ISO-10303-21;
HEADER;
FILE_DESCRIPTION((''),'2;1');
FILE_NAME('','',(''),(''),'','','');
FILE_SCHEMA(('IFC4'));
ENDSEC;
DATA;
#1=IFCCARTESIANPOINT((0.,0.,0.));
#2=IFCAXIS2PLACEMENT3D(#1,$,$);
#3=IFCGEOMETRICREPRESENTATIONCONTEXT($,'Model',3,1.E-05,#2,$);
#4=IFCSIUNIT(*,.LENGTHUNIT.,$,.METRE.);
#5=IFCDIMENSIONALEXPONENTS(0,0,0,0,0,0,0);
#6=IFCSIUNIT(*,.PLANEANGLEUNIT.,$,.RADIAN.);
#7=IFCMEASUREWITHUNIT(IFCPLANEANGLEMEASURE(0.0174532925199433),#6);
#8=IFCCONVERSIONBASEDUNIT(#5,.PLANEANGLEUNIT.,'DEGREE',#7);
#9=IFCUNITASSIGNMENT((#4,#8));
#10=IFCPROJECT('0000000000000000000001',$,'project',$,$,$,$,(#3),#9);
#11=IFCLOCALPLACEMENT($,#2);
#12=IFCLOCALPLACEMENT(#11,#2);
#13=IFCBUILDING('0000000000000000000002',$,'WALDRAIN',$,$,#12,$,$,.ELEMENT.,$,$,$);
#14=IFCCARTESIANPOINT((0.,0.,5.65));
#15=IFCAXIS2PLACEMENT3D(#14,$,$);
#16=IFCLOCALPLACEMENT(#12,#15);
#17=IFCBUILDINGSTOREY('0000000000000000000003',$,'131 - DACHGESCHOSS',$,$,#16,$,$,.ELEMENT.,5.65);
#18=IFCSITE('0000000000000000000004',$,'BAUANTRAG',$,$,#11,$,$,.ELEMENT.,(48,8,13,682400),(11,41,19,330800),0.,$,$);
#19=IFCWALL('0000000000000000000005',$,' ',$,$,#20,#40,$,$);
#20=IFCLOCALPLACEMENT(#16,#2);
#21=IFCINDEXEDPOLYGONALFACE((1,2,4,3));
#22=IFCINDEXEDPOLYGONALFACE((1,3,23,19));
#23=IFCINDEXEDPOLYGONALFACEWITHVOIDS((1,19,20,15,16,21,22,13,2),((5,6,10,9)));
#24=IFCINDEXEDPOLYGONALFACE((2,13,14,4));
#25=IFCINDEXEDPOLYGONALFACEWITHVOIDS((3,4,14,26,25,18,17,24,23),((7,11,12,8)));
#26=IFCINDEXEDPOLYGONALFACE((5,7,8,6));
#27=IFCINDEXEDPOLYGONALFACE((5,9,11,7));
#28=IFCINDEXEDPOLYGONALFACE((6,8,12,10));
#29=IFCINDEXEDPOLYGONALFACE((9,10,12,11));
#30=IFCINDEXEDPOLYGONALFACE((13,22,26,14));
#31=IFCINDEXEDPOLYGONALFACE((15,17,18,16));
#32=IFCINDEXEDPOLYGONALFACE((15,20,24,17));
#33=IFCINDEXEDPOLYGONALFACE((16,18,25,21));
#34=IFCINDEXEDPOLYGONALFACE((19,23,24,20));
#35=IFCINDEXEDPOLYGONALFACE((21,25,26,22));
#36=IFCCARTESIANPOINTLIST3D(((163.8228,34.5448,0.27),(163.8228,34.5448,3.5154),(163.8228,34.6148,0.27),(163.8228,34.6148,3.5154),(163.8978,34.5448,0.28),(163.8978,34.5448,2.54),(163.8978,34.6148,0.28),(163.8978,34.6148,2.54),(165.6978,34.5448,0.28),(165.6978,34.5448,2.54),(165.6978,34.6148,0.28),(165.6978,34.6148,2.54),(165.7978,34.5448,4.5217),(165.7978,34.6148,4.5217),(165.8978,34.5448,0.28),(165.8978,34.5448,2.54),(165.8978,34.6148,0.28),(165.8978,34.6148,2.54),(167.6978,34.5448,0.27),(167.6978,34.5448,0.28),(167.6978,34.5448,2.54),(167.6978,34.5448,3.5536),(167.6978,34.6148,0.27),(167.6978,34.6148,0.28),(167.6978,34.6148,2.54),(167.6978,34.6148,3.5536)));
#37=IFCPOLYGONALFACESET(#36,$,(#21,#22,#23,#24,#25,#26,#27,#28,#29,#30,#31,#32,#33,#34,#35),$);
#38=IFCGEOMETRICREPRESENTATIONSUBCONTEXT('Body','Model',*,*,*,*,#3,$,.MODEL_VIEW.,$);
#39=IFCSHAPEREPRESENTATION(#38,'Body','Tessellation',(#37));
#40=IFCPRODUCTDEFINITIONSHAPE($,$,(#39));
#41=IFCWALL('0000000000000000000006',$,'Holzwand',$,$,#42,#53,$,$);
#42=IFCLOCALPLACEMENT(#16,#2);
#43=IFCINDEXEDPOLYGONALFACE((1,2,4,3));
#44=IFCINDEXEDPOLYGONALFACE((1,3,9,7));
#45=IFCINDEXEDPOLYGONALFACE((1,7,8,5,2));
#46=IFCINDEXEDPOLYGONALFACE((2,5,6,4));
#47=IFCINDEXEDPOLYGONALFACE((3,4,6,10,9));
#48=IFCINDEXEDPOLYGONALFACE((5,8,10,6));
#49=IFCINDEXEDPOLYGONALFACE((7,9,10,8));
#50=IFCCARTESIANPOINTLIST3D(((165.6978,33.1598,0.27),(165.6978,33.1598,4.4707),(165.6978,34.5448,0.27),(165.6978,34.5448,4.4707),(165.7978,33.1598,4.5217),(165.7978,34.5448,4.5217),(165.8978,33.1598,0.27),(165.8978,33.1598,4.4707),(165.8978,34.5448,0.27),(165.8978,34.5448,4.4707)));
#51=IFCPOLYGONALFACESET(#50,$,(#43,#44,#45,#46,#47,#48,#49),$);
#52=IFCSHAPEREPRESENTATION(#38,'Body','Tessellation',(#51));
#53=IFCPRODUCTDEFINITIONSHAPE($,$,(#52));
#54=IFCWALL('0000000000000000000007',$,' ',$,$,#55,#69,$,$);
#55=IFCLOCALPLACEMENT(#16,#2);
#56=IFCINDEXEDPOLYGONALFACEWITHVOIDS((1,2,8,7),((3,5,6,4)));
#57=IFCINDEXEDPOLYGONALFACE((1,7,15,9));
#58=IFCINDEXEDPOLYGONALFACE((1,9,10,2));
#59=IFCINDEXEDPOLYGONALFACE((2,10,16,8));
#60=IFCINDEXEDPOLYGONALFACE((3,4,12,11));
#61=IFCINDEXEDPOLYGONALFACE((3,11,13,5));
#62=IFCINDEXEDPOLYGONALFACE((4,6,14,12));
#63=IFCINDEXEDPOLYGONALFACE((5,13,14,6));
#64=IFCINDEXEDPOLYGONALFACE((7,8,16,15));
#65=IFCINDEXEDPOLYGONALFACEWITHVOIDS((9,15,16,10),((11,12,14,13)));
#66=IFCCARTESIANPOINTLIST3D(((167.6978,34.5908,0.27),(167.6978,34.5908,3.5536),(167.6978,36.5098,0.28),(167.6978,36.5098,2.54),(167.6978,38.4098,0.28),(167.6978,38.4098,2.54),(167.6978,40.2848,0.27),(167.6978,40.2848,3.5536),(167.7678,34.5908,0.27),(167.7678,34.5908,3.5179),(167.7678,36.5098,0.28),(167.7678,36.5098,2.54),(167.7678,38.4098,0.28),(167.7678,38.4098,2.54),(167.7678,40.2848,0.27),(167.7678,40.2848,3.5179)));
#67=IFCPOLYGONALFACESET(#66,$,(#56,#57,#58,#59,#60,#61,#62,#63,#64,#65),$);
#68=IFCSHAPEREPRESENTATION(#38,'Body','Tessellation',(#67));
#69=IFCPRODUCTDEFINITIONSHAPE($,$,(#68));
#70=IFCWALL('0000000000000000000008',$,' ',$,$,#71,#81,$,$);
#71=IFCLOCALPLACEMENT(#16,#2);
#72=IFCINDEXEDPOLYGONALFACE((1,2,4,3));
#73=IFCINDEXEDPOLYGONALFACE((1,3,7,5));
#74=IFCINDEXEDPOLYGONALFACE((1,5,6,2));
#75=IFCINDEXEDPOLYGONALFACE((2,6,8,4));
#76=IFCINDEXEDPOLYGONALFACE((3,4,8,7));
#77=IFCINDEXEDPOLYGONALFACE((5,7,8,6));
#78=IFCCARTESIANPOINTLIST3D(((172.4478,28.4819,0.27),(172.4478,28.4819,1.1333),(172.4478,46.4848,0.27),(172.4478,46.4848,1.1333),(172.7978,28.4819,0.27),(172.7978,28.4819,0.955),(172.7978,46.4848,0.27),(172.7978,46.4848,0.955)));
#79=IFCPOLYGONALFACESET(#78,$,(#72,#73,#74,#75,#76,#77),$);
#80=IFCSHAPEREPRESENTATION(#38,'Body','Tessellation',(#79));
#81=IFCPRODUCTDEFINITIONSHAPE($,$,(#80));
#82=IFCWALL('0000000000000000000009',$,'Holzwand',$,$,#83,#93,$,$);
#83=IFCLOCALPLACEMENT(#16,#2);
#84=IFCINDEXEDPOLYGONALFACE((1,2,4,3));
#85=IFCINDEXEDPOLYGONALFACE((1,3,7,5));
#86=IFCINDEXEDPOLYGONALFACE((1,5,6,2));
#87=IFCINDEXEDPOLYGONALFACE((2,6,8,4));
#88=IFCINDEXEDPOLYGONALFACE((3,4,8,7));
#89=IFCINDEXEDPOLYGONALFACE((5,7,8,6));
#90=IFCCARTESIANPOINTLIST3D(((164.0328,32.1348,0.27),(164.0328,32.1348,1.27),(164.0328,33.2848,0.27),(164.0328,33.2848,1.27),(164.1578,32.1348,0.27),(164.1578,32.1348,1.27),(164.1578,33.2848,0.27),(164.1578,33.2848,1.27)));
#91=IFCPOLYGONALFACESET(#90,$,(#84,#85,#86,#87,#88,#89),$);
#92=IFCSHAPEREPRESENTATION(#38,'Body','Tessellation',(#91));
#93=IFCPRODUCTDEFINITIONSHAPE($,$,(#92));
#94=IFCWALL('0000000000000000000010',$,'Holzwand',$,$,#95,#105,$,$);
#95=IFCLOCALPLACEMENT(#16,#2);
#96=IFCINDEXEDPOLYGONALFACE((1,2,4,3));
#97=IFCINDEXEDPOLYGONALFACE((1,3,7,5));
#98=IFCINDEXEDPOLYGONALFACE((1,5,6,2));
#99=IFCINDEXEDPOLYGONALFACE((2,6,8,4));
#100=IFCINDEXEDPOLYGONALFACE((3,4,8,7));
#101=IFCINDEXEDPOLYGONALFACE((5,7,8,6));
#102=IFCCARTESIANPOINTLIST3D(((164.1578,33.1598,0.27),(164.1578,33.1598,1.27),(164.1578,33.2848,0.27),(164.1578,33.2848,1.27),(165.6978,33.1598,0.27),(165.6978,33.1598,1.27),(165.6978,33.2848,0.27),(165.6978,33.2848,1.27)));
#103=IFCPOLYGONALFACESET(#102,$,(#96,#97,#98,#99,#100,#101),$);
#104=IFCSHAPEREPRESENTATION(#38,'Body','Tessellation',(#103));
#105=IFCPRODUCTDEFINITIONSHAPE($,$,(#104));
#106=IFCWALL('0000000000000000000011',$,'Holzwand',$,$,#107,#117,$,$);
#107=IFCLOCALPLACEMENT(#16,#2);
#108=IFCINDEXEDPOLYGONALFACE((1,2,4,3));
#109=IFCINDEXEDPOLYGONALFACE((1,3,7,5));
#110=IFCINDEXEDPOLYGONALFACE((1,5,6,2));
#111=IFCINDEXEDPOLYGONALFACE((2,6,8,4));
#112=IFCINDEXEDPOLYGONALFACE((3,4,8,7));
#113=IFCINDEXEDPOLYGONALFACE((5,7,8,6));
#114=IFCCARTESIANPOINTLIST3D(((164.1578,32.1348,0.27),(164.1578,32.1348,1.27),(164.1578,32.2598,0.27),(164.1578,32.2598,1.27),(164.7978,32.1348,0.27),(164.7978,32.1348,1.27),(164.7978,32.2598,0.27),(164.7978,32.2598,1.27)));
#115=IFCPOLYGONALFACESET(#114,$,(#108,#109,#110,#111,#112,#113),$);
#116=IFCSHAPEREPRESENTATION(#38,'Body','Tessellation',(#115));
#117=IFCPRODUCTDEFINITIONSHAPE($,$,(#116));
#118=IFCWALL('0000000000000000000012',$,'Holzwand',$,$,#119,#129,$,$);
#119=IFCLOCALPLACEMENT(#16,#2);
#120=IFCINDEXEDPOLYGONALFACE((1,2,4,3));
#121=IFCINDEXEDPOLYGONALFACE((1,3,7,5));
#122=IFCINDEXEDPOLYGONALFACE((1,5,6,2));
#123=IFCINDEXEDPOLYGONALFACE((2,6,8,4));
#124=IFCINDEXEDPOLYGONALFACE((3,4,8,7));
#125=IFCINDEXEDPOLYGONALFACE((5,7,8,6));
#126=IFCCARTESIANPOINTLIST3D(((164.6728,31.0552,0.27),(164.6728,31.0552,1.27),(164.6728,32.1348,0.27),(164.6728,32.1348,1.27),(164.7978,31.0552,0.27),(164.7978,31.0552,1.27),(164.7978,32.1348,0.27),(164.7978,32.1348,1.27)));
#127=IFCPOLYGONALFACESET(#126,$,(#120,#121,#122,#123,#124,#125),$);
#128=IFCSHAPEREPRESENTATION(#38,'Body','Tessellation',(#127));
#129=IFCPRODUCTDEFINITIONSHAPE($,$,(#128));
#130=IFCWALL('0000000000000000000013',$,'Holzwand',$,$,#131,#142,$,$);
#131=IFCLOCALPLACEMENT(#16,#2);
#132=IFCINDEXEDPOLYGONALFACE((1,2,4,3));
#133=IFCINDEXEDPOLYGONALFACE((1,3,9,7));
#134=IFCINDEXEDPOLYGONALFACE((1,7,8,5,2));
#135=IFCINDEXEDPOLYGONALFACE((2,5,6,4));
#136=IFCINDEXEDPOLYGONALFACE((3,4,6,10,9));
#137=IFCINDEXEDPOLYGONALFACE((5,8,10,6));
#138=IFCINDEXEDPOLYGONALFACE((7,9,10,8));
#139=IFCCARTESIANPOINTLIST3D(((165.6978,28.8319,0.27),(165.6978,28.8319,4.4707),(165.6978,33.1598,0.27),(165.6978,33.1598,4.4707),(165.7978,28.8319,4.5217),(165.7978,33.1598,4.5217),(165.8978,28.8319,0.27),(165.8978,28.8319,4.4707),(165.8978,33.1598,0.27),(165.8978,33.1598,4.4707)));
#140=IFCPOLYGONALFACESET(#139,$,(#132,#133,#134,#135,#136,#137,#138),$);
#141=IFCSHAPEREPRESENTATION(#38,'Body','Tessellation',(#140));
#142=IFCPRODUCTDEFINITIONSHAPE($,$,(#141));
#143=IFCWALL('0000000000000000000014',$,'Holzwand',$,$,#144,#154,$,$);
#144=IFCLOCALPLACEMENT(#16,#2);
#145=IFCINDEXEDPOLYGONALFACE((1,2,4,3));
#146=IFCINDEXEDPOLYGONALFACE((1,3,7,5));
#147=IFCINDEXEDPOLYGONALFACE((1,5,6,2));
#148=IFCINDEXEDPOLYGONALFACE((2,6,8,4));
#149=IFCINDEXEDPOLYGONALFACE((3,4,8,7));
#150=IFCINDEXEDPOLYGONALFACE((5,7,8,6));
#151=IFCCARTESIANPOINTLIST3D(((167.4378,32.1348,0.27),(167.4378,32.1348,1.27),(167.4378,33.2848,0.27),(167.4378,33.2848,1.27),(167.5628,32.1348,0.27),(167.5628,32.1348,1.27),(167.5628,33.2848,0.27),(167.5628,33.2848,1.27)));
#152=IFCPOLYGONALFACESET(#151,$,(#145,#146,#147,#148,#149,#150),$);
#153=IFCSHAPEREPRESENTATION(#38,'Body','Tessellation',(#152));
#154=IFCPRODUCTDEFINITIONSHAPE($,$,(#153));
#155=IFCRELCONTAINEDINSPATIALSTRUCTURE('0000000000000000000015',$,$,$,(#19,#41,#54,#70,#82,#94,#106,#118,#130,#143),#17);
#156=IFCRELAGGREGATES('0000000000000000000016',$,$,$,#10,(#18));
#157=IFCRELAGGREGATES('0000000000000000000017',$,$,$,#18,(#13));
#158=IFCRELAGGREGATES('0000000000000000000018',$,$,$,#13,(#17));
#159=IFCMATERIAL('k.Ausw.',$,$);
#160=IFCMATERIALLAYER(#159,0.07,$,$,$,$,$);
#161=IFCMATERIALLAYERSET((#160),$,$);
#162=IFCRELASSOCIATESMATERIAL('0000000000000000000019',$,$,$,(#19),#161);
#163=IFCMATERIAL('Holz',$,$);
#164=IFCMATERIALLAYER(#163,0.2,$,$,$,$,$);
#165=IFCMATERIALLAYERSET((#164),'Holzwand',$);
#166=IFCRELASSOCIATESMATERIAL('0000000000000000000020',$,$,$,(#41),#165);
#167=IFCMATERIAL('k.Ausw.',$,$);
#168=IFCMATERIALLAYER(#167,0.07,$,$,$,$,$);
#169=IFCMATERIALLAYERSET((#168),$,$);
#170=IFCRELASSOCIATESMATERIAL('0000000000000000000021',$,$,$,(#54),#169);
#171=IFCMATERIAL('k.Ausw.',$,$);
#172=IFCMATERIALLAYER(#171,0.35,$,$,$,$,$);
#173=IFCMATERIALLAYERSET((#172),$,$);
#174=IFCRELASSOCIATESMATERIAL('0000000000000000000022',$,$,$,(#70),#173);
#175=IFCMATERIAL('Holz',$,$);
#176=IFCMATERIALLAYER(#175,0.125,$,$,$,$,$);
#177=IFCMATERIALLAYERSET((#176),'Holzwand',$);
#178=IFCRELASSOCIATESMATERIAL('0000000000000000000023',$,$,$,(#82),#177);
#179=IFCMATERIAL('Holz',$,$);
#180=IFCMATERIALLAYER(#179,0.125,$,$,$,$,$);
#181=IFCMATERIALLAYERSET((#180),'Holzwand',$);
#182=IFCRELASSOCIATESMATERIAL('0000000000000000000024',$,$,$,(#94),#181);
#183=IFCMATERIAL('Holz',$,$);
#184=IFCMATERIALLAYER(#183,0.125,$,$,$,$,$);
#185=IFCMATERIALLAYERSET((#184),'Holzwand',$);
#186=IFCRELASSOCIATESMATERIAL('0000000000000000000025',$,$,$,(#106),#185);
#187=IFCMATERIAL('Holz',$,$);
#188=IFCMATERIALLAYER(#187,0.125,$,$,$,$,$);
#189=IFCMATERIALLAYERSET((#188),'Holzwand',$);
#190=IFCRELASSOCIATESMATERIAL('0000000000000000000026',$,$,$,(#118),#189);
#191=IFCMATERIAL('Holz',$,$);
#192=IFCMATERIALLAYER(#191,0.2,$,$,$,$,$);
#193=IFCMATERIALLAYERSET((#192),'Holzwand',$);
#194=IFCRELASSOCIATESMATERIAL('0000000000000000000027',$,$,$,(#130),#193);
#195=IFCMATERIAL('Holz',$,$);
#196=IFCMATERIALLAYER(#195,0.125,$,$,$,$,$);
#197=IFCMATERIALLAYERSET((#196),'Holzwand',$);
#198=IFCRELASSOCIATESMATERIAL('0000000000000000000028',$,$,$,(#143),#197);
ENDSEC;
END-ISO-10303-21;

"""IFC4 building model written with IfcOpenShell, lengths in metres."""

from ifc_helpers import new_model, entity, si_unit, converted_unit, frame, frame_2d, origin, origin_with_axes, place, context, subcontext, project, spatial, polyline, rectangle, outline, extrude, clip, halfspace, bounded_halfspace, material, layer, layer_set, layer_usage, element, save


model = new_model("IFC4")

# Units and contexts
model_context = context("Model", 3, precision=1e-05, world=origin())
body_context = subcontext(model_context, "Body", "Model", "MODEL_VIEW")
ifc_project = project(units=[si_unit("LENGTHUNIT", "METRE"), converted_unit("PLANEANGLEUNIT", "DEGREE", entity("IfcPlaneAngleMeasure", 0.0174532925199433), si_unit("PLANEANGLEUNIT", "RADIAN"), dimensions=[0, 0, 0, 0, 0, 0, 0])], contexts=[model_context])

# Site, building, storey
site_placement = place(None, origin())
site = spatial("IfcSite", under=ifc_project, at=site_placement, Name="BAUANTRAG", CompositionType="ELEMENT", RefLatitude=(48, 8, 13, 682400), RefLongitude=(11, 41, 19, 330800), RefElevation=0.0)
building_placement = place(site_placement, origin())
building = spatial("IfcBuilding", under=site, at=building_placement, Name="WALDRAIN", CompositionType="ELEMENT")
storey_placement = place(building_placement, frame((0.0, 0.0, 5.65)))
storey = spatial("IfcBuildingStorey", under=building, at=storey_placement, Name="131 - DACHGESCHOSS", CompositionType="ELEMENT", Elevation=5.65)

# Wall, openings
ifc_material_1 = material(Name="k.Ausw.")
ifc_layer_1 = layer(ifc_material_1, 0.07)
ifc_layer_set_1 = layer_set([ifc_layer_1])
ifc_layer_usage_1 = layer_usage(ifc_layer_set_1, "AXIS2", "POSITIVE", 0.0)
wall_1_placement = place(storey_placement, frame((163.8228, 34.5448, 0.27)))
wall_1 = element("IfcWall", 1, at=wall_1_placement, inside=storey, material=ifc_layer_usage_1, Name=" ", context=body_context, shape_type="Clipping", body=[
    clip(clip(extrude(rectangle(XDim=3.875, YDim=0.07, at=frame_2d((1.9375, 0.035), x_axis=(1.0, 0.0))), origin_with_axes(), (0.0, 0.0, 1.0), 4.2517), bounded_halfspace(frame((0.9875, 0.035, 3.7485), z_axis=(0.45399, 0.0, -0.891007), x_axis=(0.891007, 0.0, 0.45399)), True, origin_with_axes(), polyline([(0.0, 0.0), (1.975, 0.0), (1.975, 0.07), (0.0, 0.07), (0.0, 0.0)]))), bounded_halfspace(frame((2.925, 0.035, 3.7676), z_axis=(-0.45399, 0.0, -0.891007), x_axis=(-0.891007, 0.0, 0.45399)), True, origin_with_axes(), polyline([(3.875, 0.07), (1.975, 0.07), (1.975, 0.0), (3.875, 0.0), (3.875, 0.07)]))),
])
opening_1_placement = place(wall_1_placement, frame((2.075, 0.0, 0.01), z_axis=(0.0, 1.0, 0.0), x_axis=(0.0, 0.0, 1.0)))
element("IfcOpeningElement", 2, at=opening_1_placement, cuts=wall_1, ObjectType="Opening", context=body_context, shape_type="SweptSolid", body=[
    extrude(outline(polyline([(0.0, 1.8), (2.26, 1.8), (2.26, 0.0), (0.0, 0.0), (0.0, 1.8)])), origin_with_axes(), (0.0, 0.0, 1.0), 0.07),
])
opening_2_placement = place(wall_1_placement, frame((0.075, 0.0, 0.01), z_axis=(0.0, 1.0, 0.0), x_axis=(0.0, 0.0, 1.0)))
element("IfcOpeningElement", 3, at=opening_2_placement, cuts=wall_1, ObjectType="Opening", context=body_context, shape_type="SweptSolid", body=[
    extrude(outline(polyline([(0.0, 1.8), (2.26, 1.8), (2.26, 0.0), (0.0, 0.0), (0.0, 1.8)])), origin_with_axes(), (0.0, 0.0, 1.0), 0.07),
])

# Wall
ifc_material_2 = material(Name="Holz")
ifc_layer_2 = layer(ifc_material_2, 0.2)
ifc_layer_set_2 = layer_set([ifc_layer_2], Name="Holzwand")
ifc_layer_usage_2 = layer_usage(ifc_layer_set_2, "AXIS2", "POSITIVE", 0.0)
wall_2_placement = place(storey_placement, frame((165.6978, 34.5448, 0.27), z_axis=(0.0, 0.0, 1.0), x_axis=(0.0, -1.0, 0.0)))
element("IfcWall", 4, at=wall_2_placement, inside=storey, material=ifc_layer_usage_2, Name="Holzwand", context=body_context, shape_type="Clipping", body=[
    clip(clip(extrude(rectangle(XDim=1.385, YDim=0.2, at=frame_2d((0.6925, 0.1), x_axis=(1.0, 0.0))), origin_with_axes(), (0.0, 0.0, 1.0), 4.2517), bounded_halfspace(frame((0.6925, 0.05, 4.2262), z_axis=(0.0, 0.45399, -0.891007), x_axis=(0.0, 0.891007, 0.45399)), True, origin_with_axes(), polyline([(1.385, 0.0), (1.385, 0.1), (0.0, 0.1), (0.0, 0.0), (1.385, 0.0)]))), bounded_halfspace(frame((0.6925, 0.15, 4.2262), z_axis=(0.0, -0.45399, -0.891007), x_axis=(0.0, -0.891007, 0.45399)), True, origin_with_axes(), polyline([(0.0, 0.2), (0.0, 0.1), (1.385, 0.1), (1.385, 0.2), (0.0, 0.2)]))),
])

# Wall, opening
ifc_material_3 = material(Name="k.Ausw.")
ifc_layer_3 = layer(ifc_material_3, 0.07)
ifc_layer_set_3 = layer_set([ifc_layer_3])
ifc_layer_usage_3 = layer_usage(ifc_layer_set_3, "AXIS2", "POSITIVE", -0.07)
wall_3_placement = place(storey_placement, frame((167.7678, 34.5908, 0.27), z_axis=(0.0, 0.0, 1.0), x_axis=(0.0, 1.0, 0.0)))
wall_3 = element("IfcWall", 5, at=wall_3_placement, inside=storey, material=ifc_layer_usage_3, Name=" ", context=body_context, shape_type="Clipping", body=[
    clip(extrude(rectangle(XDim=5.694, YDim=0.07, at=frame_2d((2.847, 0.035), x_axis=(1.0, 0.0))), origin_with_axes(), (0.0, 0.0, 1.0), 3.2836), halfspace(frame((2.847, 0.035, 3.2657), z_axis=(0.0, 0.45399, -0.891007), x_axis=(1.0, 0.0, 0.0)), True)),
])
opening_3_placement = place(wall_3_placement, frame((3.819, 0.07, 0.01), z_axis=(0.0, -1.0, 0.0), x_axis=(0.0, 0.0, 1.0)))
element("IfcOpeningElement", 6, at=opening_3_placement, cuts=wall_3, ObjectType="Opening", context=body_context, shape_type="SweptSolid", body=[
    extrude(outline(polyline([(0.0, 1.9), (2.26, 1.9), (2.26, 0.0), (0.0, 0.0), (0.0, 1.9)])), origin_with_axes(), (0.0, 0.0, 1.0), 0.07),
])

# Walls
ifc_material_4 = material(Name="k.Ausw.")
ifc_layer_4 = layer(ifc_material_4, 0.35)
ifc_layer_set_4 = layer_set([ifc_layer_4])
ifc_layer_usage_4 = layer_usage(ifc_layer_set_4, "AXIS2", "POSITIVE", 0.0)
wall_4_placement = place(storey_placement, frame((172.7978, 28.4819, 0.27), z_axis=(0.0, 0.0, 1.0), x_axis=(0.0, 1.0, 0.0)))
element("IfcWall", 7, at=wall_4_placement, inside=storey, material=ifc_layer_usage_4, Name=" ", context=body_context, shape_type="Clipping", body=[
    clip(extrude(rectangle(XDim=18.0029, YDim=0.35, at=frame_2d((9.0014, 0.175), x_axis=(1.0, 0.0))), origin_with_axes(), (0.0, 0.0, 1.0), 0.8633), halfspace(frame((9.0014, 0.175, 0.7742), z_axis=(0.0, 0.45399, -0.891007), x_axis=(0.0, -0.891007, -0.45399)), True)),
])
ifc_material_5 = material(Name="Holz")
ifc_layer_5 = layer(ifc_material_5, 0.125)
ifc_layer_set_5 = layer_set([ifc_layer_5], Name="Holzwand")
ifc_layer_usage_5 = layer_usage(ifc_layer_set_5, "AXIS2", "POSITIVE", 0.0)
wall_5_placement = place(storey_placement, frame((164.1578, 32.1348, 0.27), z_axis=(0.0, 0.0, 1.0), x_axis=(0.0, 1.0, 0.0)))
element("IfcWall", 8, at=wall_5_placement, inside=storey, material=ifc_layer_usage_5, Name="Holzwand", context=body_context, shape_type="SweptSolid", body=[
    extrude(rectangle(XDim=1.15, YDim=0.125, at=frame_2d((0.575, 0.0625), x_axis=(1.0, 0.0))), origin_with_axes(), (0.0, 0.0, 1.0), 1.0),
])
ifc_material_6 = material(Name="Holz")
ifc_layer_6 = layer(ifc_material_6, 0.125)
ifc_layer_set_6 = layer_set([ifc_layer_6], Name="Holzwand")
ifc_layer_usage_6 = layer_usage(ifc_layer_set_6, "AXIS2", "POSITIVE", 0.0)
wall_6_placement = place(storey_placement, frame((164.1578, 33.1598, 0.27)))
element("IfcWall", 9, at=wall_6_placement, inside=storey, material=ifc_layer_usage_6, Name="Holzwand", context=body_context, shape_type="SweptSolid", body=[
    extrude(rectangle(XDim=1.54, YDim=0.125, at=frame_2d((0.77, 0.0625), x_axis=(1.0, 0.0))), origin_with_axes(), (0.0, 0.0, 1.0), 1.0),
])
ifc_material_7 = material(Name="Holz")
ifc_layer_7 = layer(ifc_material_7, 0.125)
ifc_layer_set_7 = layer_set([ifc_layer_7], Name="Holzwand")
ifc_layer_usage_7 = layer_usage(ifc_layer_set_7, "AXIS2", "POSITIVE", 0.0)
wall_7_placement = place(storey_placement, frame((164.7978, 32.2598, 0.27), z_axis=(0.0, 0.0, 1.0), x_axis=(-1.0, 0.0, 0.0)))
element("IfcWall", 10, at=wall_7_placement, inside=storey, material=ifc_layer_usage_7, Name="Holzwand", context=body_context, shape_type="SweptSolid", body=[
    extrude(rectangle(XDim=0.64, YDim=0.125, at=frame_2d((0.32, 0.0625), x_axis=(1.0, 0.0))), origin_with_axes(), (0.0, 0.0, 1.0), 1.0),
])
ifc_material_8 = material(Name="Holz")
ifc_layer_8 = layer(ifc_material_8, 0.125)
ifc_layer_set_8 = layer_set([ifc_layer_8], Name="Holzwand")
ifc_layer_usage_8 = layer_usage(ifc_layer_set_8, "AXIS2", "POSITIVE", 0.0)
wall_8_placement = place(storey_placement, frame((164.7978, 31.0552, 0.27), z_axis=(0.0, 0.0, 1.0), x_axis=(0.0, 1.0, 0.0)))
element("IfcWall", 11, at=wall_8_placement, inside=storey, material=ifc_layer_usage_8, Name="Holzwand", context=body_context, shape_type="SweptSolid", body=[
    extrude(rectangle(XDim=1.0796, YDim=0.125, at=frame_2d((0.5398, 0.0625), x_axis=(1.0, 0.0))), origin_with_axes(), (0.0, 0.0, 1.0), 1.0),
])
ifc_material_9 = material(Name="Holz")
ifc_layer_9 = layer(ifc_material_9, 0.2)
ifc_layer_set_9 = layer_set([ifc_layer_9], Name="Holzwand")
ifc_layer_usage_9 = layer_usage(ifc_layer_set_9, "AXIS2", "POSITIVE", 0.0)
wall_9_placement = place(storey_placement, frame((165.6978, 33.1598, 0.27), z_axis=(0.0, 0.0, 1.0), x_axis=(0.0, -1.0, 0.0)))
element("IfcWall", 12, at=wall_9_placement, inside=storey, material=ifc_layer_usage_9, Name="Holzwand", context=body_context, shape_type="Clipping", body=[
    clip(clip(extrude(rectangle(XDim=4.3279, YDim=0.2, at=frame_2d((2.1639, 0.1), x_axis=(1.0, 0.0))), origin_with_axes(), (0.0, 0.0, 1.0), 4.2517), bounded_halfspace(frame((2.1639, 0.05, 4.2262), z_axis=(0.0, 0.45399, -0.891007), x_axis=(0.0, 0.891007, 0.45399)), True, origin_with_axes(), polyline([(4.3279, 0.0), (4.3279, 0.1), (0.0, 0.1), (0.0, 0.0), (4.3279, 0.0)]))), bounded_halfspace(frame((2.1639, 0.15, 4.2262), z_axis=(0.0, -0.45399, -0.891007), x_axis=(0.0, -0.891007, 0.45399)), True, origin_with_axes(), polyline([(0.0, 0.2), (0.0, 0.1), (4.3279, 0.1), (4.3279, 0.2), (0.0, 0.2)]))),
])
ifc_material_10 = material(Name="Holz")
ifc_layer_10 = layer(ifc_material_10, 0.125)
ifc_layer_set_10 = layer_set([ifc_layer_10], Name="Holzwand")
ifc_layer_usage_10 = layer_usage(ifc_layer_set_10, "AXIS2", "POSITIVE", 0.0)
wall_10_placement = place(storey_placement, frame((167.4378, 33.2848, 0.27), z_axis=(0.0, 0.0, 1.0), x_axis=(0.0, -1.0, 0.0)))
element("IfcWall", 13, at=wall_10_placement, inside=storey, material=ifc_layer_usage_10, Name="Holzwand", context=body_context, shape_type="SweptSolid", body=[
    extrude(rectangle(XDim=1.15, YDim=0.125, at=frame_2d((0.575, 0.0625), x_axis=(1.0, 0.0))), origin_with_axes(), (0.0, 0.0, 1.0), 1.0),
])

save(model, "model.ifc")
